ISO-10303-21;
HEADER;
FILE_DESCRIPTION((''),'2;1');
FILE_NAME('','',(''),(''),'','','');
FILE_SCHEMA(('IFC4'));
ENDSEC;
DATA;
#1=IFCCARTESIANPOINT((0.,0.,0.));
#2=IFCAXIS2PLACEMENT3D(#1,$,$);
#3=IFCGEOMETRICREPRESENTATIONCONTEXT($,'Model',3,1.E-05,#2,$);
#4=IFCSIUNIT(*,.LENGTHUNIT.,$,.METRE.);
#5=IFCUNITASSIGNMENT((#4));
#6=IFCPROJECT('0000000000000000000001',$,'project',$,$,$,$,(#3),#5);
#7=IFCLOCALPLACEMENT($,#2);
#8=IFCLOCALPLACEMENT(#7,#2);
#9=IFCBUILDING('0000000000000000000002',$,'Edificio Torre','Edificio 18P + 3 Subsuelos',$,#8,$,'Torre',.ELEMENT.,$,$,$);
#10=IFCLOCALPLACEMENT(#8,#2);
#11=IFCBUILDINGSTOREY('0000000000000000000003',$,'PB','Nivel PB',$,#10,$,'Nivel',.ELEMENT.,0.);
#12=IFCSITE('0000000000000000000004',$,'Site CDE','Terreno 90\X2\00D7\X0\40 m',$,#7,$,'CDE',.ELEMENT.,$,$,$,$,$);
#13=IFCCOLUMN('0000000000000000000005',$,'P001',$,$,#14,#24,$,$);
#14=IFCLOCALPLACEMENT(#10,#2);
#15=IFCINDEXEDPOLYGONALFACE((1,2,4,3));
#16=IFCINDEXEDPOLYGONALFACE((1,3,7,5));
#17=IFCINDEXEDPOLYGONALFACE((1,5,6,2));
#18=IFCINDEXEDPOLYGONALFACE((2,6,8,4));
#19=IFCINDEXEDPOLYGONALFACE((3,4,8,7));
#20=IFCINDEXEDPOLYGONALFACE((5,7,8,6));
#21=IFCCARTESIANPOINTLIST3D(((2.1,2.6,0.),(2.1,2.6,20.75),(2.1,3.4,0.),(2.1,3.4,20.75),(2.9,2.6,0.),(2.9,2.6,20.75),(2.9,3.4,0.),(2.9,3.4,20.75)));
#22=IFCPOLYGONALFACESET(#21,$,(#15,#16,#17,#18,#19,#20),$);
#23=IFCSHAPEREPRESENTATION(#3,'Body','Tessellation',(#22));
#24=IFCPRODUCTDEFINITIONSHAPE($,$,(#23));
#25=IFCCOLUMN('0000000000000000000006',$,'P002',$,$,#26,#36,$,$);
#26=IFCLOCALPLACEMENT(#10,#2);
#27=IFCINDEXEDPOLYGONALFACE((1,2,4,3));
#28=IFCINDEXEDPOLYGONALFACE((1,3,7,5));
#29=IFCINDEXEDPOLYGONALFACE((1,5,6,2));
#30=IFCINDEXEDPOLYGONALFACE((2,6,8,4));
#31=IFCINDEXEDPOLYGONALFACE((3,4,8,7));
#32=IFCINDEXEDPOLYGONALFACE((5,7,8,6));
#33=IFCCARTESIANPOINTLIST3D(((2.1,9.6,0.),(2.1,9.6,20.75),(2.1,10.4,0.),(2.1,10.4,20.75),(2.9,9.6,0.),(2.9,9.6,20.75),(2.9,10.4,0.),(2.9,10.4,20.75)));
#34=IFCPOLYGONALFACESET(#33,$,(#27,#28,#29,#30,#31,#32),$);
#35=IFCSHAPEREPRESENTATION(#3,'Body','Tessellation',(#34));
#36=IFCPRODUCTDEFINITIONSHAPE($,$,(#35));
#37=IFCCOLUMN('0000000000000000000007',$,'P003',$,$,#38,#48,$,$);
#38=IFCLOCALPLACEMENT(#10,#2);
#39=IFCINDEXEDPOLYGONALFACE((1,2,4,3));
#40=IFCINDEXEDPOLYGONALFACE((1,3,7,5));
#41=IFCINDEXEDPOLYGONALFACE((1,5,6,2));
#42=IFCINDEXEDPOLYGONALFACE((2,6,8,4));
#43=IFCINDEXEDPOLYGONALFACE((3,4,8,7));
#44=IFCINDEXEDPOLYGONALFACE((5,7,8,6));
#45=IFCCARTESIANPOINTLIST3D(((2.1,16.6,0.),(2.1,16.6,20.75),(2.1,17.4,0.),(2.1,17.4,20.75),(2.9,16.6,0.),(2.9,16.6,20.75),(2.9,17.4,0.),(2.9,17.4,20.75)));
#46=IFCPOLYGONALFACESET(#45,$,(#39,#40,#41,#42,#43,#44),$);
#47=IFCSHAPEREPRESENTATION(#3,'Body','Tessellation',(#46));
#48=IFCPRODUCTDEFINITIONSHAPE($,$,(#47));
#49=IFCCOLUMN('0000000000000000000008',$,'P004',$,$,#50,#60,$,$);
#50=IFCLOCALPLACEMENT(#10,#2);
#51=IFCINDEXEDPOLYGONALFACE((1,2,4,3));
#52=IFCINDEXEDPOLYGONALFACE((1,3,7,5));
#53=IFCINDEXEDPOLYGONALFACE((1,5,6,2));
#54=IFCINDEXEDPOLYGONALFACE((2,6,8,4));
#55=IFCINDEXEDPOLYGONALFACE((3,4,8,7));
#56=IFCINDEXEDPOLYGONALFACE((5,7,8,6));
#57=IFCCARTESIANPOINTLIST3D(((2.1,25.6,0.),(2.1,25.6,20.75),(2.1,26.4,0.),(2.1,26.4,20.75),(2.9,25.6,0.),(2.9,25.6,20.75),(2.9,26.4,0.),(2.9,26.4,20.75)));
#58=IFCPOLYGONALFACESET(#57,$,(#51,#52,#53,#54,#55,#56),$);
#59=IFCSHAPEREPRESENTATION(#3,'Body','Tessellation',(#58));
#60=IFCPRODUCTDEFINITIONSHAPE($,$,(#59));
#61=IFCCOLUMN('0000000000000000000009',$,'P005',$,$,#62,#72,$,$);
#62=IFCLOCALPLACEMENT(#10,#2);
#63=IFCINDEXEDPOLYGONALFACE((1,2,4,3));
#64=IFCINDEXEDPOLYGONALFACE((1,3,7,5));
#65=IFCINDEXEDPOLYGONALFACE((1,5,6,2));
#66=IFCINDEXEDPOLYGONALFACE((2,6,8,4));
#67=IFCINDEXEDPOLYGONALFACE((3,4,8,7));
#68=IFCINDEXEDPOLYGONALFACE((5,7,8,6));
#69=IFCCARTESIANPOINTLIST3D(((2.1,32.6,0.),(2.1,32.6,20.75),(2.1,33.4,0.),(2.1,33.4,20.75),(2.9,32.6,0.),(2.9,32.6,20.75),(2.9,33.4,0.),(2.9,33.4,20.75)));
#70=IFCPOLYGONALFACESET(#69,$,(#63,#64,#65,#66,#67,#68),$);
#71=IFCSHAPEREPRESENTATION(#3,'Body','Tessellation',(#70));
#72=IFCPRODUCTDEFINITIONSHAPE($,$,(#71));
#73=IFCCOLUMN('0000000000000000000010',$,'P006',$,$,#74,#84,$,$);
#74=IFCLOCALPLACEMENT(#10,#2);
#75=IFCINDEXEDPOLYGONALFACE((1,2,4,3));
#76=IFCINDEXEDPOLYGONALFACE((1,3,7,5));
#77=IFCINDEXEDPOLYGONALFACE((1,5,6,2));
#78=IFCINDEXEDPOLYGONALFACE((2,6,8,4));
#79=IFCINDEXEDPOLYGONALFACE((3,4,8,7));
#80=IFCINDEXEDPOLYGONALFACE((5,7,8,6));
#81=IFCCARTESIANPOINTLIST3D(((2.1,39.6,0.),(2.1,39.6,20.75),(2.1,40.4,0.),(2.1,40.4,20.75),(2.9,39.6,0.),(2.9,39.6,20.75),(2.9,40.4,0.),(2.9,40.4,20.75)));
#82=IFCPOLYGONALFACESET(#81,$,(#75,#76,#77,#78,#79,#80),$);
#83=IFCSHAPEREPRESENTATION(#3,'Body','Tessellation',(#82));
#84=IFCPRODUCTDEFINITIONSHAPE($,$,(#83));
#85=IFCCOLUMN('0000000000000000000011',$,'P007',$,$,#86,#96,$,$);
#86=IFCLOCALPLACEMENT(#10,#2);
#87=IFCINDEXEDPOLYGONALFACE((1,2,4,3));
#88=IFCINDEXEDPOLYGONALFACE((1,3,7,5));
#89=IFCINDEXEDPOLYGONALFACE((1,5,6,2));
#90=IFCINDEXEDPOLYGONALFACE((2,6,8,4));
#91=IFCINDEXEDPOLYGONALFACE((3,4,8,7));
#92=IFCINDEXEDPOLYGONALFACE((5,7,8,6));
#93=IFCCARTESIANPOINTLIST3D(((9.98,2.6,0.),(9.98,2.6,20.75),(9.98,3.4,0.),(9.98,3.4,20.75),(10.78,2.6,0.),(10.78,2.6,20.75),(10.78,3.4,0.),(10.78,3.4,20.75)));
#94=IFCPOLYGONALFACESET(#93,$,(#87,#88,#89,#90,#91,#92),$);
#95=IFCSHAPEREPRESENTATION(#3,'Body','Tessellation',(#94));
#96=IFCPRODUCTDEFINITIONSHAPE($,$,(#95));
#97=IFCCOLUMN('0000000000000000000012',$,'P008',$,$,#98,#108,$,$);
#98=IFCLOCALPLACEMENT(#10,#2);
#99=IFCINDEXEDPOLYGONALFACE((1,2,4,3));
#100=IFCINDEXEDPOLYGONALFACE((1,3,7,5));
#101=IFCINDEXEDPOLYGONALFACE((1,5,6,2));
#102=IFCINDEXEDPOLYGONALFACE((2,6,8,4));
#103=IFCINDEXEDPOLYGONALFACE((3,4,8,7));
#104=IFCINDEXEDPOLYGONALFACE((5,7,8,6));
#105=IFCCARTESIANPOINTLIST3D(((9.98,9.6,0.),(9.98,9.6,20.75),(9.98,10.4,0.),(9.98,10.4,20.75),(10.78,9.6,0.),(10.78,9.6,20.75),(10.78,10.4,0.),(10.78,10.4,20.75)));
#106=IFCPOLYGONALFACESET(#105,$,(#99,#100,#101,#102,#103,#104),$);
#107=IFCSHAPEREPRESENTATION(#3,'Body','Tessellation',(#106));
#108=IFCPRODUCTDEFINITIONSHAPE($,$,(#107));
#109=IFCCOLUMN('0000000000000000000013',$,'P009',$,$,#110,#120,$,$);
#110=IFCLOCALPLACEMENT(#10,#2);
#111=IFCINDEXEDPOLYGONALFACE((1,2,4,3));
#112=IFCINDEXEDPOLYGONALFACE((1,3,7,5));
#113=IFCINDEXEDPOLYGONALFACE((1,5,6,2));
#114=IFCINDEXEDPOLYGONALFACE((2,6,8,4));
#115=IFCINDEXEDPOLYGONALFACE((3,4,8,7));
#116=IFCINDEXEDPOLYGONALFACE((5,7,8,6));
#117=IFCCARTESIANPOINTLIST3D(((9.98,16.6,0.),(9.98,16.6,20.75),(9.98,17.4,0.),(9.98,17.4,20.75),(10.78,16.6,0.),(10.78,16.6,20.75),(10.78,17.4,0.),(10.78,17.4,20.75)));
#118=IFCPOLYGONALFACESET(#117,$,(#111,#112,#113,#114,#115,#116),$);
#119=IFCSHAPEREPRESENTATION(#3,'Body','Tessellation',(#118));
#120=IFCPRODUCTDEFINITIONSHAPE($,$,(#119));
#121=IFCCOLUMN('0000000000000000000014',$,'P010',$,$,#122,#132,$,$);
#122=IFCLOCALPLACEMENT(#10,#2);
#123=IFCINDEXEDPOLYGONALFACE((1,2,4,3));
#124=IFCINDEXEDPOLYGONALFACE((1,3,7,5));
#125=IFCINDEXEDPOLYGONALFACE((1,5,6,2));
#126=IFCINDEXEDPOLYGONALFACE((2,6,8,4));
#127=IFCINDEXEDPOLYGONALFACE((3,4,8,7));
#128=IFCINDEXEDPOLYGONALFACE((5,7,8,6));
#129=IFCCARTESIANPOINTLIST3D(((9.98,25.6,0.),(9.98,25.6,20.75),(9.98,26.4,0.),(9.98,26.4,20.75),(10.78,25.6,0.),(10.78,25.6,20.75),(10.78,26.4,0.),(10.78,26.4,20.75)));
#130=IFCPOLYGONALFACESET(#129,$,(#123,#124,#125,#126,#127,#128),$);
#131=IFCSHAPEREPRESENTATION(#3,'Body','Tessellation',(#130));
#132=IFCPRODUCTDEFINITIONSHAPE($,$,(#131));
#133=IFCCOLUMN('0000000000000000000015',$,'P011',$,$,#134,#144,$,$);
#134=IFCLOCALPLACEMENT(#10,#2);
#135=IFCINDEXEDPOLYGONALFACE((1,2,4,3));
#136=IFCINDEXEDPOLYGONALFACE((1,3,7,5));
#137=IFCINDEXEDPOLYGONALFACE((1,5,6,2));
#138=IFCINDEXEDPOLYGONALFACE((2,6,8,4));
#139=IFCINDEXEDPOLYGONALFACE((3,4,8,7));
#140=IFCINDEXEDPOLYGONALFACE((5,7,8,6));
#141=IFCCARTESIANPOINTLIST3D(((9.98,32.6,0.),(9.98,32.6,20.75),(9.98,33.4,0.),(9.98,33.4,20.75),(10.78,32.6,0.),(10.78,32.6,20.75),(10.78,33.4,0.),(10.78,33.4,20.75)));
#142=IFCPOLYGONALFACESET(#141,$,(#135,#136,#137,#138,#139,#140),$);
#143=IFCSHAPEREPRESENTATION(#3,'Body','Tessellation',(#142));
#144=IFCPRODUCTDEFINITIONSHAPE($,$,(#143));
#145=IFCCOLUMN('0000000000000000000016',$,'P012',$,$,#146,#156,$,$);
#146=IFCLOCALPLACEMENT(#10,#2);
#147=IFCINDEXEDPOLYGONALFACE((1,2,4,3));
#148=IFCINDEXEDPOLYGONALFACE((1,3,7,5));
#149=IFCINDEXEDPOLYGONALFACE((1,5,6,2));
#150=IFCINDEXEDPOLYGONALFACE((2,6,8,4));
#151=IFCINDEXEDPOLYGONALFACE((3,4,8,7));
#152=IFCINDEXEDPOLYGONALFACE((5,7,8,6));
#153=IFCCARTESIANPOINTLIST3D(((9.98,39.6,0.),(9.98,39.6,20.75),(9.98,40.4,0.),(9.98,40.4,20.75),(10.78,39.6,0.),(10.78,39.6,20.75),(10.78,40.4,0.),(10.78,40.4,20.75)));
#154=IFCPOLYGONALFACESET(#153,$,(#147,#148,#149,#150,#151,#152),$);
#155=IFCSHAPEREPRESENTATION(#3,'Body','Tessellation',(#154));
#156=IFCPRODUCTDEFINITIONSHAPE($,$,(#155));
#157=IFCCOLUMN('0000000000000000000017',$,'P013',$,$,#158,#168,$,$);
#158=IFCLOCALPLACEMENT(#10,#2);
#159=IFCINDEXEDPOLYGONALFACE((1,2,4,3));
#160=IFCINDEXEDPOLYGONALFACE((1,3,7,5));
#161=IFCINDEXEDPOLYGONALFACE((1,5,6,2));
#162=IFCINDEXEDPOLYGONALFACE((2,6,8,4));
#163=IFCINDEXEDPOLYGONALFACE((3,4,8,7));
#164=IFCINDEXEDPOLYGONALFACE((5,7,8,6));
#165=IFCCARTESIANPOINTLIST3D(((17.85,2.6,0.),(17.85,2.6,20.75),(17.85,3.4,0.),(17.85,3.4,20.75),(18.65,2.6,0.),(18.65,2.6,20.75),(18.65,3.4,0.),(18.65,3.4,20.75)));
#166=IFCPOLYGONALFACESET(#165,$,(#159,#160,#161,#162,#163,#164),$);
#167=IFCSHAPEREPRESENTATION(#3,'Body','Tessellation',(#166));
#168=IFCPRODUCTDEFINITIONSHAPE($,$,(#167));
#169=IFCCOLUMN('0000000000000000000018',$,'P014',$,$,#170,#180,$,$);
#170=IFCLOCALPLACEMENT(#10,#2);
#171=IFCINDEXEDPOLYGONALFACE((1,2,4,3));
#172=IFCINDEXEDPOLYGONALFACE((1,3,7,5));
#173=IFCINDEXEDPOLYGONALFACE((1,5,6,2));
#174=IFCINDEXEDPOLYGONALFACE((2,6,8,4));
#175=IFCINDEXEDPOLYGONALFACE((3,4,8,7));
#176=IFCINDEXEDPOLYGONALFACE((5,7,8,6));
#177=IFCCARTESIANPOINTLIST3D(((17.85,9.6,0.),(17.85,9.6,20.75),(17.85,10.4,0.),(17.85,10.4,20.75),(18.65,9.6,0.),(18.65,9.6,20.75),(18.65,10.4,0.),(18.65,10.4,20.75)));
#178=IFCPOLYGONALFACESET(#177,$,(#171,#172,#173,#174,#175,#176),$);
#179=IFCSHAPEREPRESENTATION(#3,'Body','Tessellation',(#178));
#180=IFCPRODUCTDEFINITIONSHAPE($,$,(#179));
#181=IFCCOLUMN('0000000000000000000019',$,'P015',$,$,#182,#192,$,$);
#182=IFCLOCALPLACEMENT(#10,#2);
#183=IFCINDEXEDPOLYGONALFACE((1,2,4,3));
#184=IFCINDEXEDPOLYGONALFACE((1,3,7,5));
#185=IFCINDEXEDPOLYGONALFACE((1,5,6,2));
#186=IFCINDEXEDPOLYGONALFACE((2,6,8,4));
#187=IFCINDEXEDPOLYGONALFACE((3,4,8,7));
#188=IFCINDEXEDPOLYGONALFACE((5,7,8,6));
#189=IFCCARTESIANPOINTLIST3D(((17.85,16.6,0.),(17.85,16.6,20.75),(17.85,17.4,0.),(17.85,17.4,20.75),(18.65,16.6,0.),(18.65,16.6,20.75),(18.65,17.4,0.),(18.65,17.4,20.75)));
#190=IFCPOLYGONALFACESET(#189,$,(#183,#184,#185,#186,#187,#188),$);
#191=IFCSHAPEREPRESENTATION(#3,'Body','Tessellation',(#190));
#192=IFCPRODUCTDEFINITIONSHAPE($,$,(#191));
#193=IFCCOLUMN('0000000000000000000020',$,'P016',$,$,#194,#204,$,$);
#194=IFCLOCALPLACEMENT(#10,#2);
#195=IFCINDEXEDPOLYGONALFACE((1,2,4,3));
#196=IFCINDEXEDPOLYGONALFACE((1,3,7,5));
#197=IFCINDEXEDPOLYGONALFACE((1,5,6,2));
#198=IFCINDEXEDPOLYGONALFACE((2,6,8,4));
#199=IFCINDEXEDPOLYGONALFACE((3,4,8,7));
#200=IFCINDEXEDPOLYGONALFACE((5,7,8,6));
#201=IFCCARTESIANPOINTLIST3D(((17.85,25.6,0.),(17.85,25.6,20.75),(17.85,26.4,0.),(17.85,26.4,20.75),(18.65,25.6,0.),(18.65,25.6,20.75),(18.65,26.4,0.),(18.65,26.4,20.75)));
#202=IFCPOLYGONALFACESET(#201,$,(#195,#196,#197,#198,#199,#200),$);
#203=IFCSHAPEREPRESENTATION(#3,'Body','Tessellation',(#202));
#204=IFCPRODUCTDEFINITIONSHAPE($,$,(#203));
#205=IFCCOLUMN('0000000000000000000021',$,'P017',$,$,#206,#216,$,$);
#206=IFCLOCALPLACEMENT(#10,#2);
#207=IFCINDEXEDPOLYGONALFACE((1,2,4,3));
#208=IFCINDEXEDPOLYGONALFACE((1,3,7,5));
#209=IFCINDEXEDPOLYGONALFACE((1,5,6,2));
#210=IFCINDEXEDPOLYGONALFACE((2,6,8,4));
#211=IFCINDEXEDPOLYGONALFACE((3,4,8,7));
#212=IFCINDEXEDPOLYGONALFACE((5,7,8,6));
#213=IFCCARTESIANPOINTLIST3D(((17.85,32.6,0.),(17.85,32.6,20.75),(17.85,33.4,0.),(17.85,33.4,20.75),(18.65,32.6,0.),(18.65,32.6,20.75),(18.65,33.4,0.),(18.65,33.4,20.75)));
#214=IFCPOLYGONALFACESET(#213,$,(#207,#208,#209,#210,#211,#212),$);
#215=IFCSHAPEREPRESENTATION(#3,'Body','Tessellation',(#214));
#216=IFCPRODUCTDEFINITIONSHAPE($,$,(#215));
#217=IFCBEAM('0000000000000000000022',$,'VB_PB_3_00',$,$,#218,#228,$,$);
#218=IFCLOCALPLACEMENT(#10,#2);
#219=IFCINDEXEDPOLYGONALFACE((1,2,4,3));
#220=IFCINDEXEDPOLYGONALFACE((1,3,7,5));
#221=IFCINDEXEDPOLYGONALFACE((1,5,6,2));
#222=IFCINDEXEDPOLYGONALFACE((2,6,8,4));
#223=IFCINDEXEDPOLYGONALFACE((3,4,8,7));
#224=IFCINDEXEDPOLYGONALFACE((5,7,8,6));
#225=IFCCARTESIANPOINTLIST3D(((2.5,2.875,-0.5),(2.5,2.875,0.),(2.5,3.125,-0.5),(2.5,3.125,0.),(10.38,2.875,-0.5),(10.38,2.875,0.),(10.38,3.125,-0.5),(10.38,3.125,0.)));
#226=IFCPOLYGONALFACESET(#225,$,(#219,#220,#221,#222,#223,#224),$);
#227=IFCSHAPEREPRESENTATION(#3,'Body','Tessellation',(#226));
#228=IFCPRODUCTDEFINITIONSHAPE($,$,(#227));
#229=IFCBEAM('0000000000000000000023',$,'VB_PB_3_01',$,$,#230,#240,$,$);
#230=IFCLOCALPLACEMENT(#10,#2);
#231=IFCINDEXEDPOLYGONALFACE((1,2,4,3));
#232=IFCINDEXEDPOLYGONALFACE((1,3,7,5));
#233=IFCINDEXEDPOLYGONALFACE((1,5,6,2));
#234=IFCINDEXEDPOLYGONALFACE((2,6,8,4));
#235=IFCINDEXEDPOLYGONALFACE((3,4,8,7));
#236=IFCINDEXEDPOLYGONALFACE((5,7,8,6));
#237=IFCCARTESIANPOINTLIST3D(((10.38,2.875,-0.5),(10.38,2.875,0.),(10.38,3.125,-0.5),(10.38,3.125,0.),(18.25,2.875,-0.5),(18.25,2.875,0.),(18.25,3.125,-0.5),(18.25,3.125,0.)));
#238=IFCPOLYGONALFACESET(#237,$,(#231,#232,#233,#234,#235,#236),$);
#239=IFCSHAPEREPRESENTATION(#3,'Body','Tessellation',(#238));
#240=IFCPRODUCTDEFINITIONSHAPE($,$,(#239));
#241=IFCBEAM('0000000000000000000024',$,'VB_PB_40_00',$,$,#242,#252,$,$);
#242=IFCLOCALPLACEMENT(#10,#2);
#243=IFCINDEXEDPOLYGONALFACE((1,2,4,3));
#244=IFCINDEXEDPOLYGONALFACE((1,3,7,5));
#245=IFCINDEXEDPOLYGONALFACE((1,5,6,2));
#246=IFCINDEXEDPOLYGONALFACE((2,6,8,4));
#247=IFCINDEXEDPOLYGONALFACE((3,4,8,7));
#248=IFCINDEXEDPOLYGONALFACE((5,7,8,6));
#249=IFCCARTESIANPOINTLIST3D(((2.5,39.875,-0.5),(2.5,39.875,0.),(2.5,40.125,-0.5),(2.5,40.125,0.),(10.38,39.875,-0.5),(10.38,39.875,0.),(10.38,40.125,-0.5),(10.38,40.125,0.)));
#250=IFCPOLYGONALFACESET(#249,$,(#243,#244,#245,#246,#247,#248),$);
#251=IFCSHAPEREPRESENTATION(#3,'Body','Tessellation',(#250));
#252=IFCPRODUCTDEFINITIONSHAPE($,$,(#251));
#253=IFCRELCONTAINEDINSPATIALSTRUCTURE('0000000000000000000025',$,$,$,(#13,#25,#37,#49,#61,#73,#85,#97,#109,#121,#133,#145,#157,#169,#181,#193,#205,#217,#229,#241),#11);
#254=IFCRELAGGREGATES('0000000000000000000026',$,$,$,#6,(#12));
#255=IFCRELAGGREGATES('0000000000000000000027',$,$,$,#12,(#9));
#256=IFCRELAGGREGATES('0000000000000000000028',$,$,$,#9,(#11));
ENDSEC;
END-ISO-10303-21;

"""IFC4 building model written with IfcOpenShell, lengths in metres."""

from ifc_helpers import new_model, si_unit, frame, origin, origin_2d, place, context, project, spatial, rectangle, extrude, element, save


model = new_model("IFC4")

# Units and contexts
model_context = context("Model", 3, precision=1e-05, world=origin())
ifc_project = project(units=[si_unit("LENGTHUNIT", "METRE")], contexts=[model_context])

# Site, building, storey
site_placement = place(None, origin())
site = spatial("IfcSite", under=ifc_project, at=site_placement, Name="Site CDE", Description="Terreno 90×40 m", LongName="CDE", CompositionType="ELEMENT")
building_placement = place(site_placement, origin())
building = spatial("IfcBuilding", under=site, at=building_placement, Name="Edificio Torre", Description="Edificio 18P + 3 Subsuelos", LongName="Torre", CompositionType="ELEMENT")
storey_placement = place(building_placement, origin())
storey = spatial("IfcBuildingStorey", under=building, at=storey_placement, Name="PB", Description="Nivel PB", LongName="Nivel", CompositionType="ELEMENT", Elevation=0.0)

# Columns
for number, where, name in (
    (1, (2.5, 3.0, 0.0), "P001"),
    (2, (2.5, 10.0, 0.0), "P002"),
    (3, (2.5, 17.0, 0.0), "P003"),
    (4, (2.5, 26.0, 0.0), "P004"),
    (5, (2.5, 33.0, 0.0), "P005"),
    (6, (2.5, 40.0, 0.0), "P006"),
    (7, (10.38, 3.0, 0.0), "P007"),
    (8, (10.38, 10.0, 0.0), "P008"),
    (9, (10.38, 17.0, 0.0), "P009"),
    (10, (10.38, 26.0, 0.0), "P010"),
    (11, (10.38, 33.0, 0.0), "P011"),
    (12, (10.38, 40.0, 0.0), "P012"),
    (13, (18.25, 3.0, 0.0), "P013"),
    (14, (18.25, 10.0, 0.0), "P014"),
    (15, (18.25, 17.0, 0.0), "P015"),
    (16, (18.25, 26.0, 0.0), "P016"),
    (17, (18.25, 33.0, 0.0), "P017"),
):
    element("IfcColumn", number, at=place(storey_placement, frame(where)), inside=storey, Name=name, context=model_context, shape_type="SweptSolid", body=[
        extrude(rectangle(XDim=0.8, YDim=0.8, at=origin_2d()), origin(), (0.0, 0.0, 1.0), 20.75),
    ])

# Beams
beam_1_placement = place(storey_placement, frame((6.44, 3.0, -0.5)))
element("IfcBeam", 18, at=beam_1_placement, inside=storey, Name="VB_PB_3_00", context=model_context, shape_type="SweptSolid", body=[
    extrude(rectangle(XDim=7.88, YDim=0.25, at=origin_2d()), origin(), (0.0, 0.0, 1.0), 0.5),
])
beam_2_placement = place(storey_placement, frame((14.315, 3.0, -0.5)))
element("IfcBeam", 19, at=beam_2_placement, inside=storey, Name="VB_PB_3_01", context=model_context, shape_type="SweptSolid", body=[
    extrude(rectangle(XDim=7.87, YDim=0.25, at=origin_2d()), origin(), (0.0, 0.0, 1.0), 0.5),
])
beam_3_placement = place(storey_placement, frame((6.44, 40.0, -0.5)))
element("IfcBeam", 20, at=beam_3_placement, inside=storey, Name="VB_PB_40_00", context=model_context, shape_type="SweptSolid", body=[
    extrude(rectangle(XDim=7.88, YDim=0.25, at=origin_2d()), origin(), (0.0, 0.0, 1.0), 0.5),
])

save(model, "model.ifc")
